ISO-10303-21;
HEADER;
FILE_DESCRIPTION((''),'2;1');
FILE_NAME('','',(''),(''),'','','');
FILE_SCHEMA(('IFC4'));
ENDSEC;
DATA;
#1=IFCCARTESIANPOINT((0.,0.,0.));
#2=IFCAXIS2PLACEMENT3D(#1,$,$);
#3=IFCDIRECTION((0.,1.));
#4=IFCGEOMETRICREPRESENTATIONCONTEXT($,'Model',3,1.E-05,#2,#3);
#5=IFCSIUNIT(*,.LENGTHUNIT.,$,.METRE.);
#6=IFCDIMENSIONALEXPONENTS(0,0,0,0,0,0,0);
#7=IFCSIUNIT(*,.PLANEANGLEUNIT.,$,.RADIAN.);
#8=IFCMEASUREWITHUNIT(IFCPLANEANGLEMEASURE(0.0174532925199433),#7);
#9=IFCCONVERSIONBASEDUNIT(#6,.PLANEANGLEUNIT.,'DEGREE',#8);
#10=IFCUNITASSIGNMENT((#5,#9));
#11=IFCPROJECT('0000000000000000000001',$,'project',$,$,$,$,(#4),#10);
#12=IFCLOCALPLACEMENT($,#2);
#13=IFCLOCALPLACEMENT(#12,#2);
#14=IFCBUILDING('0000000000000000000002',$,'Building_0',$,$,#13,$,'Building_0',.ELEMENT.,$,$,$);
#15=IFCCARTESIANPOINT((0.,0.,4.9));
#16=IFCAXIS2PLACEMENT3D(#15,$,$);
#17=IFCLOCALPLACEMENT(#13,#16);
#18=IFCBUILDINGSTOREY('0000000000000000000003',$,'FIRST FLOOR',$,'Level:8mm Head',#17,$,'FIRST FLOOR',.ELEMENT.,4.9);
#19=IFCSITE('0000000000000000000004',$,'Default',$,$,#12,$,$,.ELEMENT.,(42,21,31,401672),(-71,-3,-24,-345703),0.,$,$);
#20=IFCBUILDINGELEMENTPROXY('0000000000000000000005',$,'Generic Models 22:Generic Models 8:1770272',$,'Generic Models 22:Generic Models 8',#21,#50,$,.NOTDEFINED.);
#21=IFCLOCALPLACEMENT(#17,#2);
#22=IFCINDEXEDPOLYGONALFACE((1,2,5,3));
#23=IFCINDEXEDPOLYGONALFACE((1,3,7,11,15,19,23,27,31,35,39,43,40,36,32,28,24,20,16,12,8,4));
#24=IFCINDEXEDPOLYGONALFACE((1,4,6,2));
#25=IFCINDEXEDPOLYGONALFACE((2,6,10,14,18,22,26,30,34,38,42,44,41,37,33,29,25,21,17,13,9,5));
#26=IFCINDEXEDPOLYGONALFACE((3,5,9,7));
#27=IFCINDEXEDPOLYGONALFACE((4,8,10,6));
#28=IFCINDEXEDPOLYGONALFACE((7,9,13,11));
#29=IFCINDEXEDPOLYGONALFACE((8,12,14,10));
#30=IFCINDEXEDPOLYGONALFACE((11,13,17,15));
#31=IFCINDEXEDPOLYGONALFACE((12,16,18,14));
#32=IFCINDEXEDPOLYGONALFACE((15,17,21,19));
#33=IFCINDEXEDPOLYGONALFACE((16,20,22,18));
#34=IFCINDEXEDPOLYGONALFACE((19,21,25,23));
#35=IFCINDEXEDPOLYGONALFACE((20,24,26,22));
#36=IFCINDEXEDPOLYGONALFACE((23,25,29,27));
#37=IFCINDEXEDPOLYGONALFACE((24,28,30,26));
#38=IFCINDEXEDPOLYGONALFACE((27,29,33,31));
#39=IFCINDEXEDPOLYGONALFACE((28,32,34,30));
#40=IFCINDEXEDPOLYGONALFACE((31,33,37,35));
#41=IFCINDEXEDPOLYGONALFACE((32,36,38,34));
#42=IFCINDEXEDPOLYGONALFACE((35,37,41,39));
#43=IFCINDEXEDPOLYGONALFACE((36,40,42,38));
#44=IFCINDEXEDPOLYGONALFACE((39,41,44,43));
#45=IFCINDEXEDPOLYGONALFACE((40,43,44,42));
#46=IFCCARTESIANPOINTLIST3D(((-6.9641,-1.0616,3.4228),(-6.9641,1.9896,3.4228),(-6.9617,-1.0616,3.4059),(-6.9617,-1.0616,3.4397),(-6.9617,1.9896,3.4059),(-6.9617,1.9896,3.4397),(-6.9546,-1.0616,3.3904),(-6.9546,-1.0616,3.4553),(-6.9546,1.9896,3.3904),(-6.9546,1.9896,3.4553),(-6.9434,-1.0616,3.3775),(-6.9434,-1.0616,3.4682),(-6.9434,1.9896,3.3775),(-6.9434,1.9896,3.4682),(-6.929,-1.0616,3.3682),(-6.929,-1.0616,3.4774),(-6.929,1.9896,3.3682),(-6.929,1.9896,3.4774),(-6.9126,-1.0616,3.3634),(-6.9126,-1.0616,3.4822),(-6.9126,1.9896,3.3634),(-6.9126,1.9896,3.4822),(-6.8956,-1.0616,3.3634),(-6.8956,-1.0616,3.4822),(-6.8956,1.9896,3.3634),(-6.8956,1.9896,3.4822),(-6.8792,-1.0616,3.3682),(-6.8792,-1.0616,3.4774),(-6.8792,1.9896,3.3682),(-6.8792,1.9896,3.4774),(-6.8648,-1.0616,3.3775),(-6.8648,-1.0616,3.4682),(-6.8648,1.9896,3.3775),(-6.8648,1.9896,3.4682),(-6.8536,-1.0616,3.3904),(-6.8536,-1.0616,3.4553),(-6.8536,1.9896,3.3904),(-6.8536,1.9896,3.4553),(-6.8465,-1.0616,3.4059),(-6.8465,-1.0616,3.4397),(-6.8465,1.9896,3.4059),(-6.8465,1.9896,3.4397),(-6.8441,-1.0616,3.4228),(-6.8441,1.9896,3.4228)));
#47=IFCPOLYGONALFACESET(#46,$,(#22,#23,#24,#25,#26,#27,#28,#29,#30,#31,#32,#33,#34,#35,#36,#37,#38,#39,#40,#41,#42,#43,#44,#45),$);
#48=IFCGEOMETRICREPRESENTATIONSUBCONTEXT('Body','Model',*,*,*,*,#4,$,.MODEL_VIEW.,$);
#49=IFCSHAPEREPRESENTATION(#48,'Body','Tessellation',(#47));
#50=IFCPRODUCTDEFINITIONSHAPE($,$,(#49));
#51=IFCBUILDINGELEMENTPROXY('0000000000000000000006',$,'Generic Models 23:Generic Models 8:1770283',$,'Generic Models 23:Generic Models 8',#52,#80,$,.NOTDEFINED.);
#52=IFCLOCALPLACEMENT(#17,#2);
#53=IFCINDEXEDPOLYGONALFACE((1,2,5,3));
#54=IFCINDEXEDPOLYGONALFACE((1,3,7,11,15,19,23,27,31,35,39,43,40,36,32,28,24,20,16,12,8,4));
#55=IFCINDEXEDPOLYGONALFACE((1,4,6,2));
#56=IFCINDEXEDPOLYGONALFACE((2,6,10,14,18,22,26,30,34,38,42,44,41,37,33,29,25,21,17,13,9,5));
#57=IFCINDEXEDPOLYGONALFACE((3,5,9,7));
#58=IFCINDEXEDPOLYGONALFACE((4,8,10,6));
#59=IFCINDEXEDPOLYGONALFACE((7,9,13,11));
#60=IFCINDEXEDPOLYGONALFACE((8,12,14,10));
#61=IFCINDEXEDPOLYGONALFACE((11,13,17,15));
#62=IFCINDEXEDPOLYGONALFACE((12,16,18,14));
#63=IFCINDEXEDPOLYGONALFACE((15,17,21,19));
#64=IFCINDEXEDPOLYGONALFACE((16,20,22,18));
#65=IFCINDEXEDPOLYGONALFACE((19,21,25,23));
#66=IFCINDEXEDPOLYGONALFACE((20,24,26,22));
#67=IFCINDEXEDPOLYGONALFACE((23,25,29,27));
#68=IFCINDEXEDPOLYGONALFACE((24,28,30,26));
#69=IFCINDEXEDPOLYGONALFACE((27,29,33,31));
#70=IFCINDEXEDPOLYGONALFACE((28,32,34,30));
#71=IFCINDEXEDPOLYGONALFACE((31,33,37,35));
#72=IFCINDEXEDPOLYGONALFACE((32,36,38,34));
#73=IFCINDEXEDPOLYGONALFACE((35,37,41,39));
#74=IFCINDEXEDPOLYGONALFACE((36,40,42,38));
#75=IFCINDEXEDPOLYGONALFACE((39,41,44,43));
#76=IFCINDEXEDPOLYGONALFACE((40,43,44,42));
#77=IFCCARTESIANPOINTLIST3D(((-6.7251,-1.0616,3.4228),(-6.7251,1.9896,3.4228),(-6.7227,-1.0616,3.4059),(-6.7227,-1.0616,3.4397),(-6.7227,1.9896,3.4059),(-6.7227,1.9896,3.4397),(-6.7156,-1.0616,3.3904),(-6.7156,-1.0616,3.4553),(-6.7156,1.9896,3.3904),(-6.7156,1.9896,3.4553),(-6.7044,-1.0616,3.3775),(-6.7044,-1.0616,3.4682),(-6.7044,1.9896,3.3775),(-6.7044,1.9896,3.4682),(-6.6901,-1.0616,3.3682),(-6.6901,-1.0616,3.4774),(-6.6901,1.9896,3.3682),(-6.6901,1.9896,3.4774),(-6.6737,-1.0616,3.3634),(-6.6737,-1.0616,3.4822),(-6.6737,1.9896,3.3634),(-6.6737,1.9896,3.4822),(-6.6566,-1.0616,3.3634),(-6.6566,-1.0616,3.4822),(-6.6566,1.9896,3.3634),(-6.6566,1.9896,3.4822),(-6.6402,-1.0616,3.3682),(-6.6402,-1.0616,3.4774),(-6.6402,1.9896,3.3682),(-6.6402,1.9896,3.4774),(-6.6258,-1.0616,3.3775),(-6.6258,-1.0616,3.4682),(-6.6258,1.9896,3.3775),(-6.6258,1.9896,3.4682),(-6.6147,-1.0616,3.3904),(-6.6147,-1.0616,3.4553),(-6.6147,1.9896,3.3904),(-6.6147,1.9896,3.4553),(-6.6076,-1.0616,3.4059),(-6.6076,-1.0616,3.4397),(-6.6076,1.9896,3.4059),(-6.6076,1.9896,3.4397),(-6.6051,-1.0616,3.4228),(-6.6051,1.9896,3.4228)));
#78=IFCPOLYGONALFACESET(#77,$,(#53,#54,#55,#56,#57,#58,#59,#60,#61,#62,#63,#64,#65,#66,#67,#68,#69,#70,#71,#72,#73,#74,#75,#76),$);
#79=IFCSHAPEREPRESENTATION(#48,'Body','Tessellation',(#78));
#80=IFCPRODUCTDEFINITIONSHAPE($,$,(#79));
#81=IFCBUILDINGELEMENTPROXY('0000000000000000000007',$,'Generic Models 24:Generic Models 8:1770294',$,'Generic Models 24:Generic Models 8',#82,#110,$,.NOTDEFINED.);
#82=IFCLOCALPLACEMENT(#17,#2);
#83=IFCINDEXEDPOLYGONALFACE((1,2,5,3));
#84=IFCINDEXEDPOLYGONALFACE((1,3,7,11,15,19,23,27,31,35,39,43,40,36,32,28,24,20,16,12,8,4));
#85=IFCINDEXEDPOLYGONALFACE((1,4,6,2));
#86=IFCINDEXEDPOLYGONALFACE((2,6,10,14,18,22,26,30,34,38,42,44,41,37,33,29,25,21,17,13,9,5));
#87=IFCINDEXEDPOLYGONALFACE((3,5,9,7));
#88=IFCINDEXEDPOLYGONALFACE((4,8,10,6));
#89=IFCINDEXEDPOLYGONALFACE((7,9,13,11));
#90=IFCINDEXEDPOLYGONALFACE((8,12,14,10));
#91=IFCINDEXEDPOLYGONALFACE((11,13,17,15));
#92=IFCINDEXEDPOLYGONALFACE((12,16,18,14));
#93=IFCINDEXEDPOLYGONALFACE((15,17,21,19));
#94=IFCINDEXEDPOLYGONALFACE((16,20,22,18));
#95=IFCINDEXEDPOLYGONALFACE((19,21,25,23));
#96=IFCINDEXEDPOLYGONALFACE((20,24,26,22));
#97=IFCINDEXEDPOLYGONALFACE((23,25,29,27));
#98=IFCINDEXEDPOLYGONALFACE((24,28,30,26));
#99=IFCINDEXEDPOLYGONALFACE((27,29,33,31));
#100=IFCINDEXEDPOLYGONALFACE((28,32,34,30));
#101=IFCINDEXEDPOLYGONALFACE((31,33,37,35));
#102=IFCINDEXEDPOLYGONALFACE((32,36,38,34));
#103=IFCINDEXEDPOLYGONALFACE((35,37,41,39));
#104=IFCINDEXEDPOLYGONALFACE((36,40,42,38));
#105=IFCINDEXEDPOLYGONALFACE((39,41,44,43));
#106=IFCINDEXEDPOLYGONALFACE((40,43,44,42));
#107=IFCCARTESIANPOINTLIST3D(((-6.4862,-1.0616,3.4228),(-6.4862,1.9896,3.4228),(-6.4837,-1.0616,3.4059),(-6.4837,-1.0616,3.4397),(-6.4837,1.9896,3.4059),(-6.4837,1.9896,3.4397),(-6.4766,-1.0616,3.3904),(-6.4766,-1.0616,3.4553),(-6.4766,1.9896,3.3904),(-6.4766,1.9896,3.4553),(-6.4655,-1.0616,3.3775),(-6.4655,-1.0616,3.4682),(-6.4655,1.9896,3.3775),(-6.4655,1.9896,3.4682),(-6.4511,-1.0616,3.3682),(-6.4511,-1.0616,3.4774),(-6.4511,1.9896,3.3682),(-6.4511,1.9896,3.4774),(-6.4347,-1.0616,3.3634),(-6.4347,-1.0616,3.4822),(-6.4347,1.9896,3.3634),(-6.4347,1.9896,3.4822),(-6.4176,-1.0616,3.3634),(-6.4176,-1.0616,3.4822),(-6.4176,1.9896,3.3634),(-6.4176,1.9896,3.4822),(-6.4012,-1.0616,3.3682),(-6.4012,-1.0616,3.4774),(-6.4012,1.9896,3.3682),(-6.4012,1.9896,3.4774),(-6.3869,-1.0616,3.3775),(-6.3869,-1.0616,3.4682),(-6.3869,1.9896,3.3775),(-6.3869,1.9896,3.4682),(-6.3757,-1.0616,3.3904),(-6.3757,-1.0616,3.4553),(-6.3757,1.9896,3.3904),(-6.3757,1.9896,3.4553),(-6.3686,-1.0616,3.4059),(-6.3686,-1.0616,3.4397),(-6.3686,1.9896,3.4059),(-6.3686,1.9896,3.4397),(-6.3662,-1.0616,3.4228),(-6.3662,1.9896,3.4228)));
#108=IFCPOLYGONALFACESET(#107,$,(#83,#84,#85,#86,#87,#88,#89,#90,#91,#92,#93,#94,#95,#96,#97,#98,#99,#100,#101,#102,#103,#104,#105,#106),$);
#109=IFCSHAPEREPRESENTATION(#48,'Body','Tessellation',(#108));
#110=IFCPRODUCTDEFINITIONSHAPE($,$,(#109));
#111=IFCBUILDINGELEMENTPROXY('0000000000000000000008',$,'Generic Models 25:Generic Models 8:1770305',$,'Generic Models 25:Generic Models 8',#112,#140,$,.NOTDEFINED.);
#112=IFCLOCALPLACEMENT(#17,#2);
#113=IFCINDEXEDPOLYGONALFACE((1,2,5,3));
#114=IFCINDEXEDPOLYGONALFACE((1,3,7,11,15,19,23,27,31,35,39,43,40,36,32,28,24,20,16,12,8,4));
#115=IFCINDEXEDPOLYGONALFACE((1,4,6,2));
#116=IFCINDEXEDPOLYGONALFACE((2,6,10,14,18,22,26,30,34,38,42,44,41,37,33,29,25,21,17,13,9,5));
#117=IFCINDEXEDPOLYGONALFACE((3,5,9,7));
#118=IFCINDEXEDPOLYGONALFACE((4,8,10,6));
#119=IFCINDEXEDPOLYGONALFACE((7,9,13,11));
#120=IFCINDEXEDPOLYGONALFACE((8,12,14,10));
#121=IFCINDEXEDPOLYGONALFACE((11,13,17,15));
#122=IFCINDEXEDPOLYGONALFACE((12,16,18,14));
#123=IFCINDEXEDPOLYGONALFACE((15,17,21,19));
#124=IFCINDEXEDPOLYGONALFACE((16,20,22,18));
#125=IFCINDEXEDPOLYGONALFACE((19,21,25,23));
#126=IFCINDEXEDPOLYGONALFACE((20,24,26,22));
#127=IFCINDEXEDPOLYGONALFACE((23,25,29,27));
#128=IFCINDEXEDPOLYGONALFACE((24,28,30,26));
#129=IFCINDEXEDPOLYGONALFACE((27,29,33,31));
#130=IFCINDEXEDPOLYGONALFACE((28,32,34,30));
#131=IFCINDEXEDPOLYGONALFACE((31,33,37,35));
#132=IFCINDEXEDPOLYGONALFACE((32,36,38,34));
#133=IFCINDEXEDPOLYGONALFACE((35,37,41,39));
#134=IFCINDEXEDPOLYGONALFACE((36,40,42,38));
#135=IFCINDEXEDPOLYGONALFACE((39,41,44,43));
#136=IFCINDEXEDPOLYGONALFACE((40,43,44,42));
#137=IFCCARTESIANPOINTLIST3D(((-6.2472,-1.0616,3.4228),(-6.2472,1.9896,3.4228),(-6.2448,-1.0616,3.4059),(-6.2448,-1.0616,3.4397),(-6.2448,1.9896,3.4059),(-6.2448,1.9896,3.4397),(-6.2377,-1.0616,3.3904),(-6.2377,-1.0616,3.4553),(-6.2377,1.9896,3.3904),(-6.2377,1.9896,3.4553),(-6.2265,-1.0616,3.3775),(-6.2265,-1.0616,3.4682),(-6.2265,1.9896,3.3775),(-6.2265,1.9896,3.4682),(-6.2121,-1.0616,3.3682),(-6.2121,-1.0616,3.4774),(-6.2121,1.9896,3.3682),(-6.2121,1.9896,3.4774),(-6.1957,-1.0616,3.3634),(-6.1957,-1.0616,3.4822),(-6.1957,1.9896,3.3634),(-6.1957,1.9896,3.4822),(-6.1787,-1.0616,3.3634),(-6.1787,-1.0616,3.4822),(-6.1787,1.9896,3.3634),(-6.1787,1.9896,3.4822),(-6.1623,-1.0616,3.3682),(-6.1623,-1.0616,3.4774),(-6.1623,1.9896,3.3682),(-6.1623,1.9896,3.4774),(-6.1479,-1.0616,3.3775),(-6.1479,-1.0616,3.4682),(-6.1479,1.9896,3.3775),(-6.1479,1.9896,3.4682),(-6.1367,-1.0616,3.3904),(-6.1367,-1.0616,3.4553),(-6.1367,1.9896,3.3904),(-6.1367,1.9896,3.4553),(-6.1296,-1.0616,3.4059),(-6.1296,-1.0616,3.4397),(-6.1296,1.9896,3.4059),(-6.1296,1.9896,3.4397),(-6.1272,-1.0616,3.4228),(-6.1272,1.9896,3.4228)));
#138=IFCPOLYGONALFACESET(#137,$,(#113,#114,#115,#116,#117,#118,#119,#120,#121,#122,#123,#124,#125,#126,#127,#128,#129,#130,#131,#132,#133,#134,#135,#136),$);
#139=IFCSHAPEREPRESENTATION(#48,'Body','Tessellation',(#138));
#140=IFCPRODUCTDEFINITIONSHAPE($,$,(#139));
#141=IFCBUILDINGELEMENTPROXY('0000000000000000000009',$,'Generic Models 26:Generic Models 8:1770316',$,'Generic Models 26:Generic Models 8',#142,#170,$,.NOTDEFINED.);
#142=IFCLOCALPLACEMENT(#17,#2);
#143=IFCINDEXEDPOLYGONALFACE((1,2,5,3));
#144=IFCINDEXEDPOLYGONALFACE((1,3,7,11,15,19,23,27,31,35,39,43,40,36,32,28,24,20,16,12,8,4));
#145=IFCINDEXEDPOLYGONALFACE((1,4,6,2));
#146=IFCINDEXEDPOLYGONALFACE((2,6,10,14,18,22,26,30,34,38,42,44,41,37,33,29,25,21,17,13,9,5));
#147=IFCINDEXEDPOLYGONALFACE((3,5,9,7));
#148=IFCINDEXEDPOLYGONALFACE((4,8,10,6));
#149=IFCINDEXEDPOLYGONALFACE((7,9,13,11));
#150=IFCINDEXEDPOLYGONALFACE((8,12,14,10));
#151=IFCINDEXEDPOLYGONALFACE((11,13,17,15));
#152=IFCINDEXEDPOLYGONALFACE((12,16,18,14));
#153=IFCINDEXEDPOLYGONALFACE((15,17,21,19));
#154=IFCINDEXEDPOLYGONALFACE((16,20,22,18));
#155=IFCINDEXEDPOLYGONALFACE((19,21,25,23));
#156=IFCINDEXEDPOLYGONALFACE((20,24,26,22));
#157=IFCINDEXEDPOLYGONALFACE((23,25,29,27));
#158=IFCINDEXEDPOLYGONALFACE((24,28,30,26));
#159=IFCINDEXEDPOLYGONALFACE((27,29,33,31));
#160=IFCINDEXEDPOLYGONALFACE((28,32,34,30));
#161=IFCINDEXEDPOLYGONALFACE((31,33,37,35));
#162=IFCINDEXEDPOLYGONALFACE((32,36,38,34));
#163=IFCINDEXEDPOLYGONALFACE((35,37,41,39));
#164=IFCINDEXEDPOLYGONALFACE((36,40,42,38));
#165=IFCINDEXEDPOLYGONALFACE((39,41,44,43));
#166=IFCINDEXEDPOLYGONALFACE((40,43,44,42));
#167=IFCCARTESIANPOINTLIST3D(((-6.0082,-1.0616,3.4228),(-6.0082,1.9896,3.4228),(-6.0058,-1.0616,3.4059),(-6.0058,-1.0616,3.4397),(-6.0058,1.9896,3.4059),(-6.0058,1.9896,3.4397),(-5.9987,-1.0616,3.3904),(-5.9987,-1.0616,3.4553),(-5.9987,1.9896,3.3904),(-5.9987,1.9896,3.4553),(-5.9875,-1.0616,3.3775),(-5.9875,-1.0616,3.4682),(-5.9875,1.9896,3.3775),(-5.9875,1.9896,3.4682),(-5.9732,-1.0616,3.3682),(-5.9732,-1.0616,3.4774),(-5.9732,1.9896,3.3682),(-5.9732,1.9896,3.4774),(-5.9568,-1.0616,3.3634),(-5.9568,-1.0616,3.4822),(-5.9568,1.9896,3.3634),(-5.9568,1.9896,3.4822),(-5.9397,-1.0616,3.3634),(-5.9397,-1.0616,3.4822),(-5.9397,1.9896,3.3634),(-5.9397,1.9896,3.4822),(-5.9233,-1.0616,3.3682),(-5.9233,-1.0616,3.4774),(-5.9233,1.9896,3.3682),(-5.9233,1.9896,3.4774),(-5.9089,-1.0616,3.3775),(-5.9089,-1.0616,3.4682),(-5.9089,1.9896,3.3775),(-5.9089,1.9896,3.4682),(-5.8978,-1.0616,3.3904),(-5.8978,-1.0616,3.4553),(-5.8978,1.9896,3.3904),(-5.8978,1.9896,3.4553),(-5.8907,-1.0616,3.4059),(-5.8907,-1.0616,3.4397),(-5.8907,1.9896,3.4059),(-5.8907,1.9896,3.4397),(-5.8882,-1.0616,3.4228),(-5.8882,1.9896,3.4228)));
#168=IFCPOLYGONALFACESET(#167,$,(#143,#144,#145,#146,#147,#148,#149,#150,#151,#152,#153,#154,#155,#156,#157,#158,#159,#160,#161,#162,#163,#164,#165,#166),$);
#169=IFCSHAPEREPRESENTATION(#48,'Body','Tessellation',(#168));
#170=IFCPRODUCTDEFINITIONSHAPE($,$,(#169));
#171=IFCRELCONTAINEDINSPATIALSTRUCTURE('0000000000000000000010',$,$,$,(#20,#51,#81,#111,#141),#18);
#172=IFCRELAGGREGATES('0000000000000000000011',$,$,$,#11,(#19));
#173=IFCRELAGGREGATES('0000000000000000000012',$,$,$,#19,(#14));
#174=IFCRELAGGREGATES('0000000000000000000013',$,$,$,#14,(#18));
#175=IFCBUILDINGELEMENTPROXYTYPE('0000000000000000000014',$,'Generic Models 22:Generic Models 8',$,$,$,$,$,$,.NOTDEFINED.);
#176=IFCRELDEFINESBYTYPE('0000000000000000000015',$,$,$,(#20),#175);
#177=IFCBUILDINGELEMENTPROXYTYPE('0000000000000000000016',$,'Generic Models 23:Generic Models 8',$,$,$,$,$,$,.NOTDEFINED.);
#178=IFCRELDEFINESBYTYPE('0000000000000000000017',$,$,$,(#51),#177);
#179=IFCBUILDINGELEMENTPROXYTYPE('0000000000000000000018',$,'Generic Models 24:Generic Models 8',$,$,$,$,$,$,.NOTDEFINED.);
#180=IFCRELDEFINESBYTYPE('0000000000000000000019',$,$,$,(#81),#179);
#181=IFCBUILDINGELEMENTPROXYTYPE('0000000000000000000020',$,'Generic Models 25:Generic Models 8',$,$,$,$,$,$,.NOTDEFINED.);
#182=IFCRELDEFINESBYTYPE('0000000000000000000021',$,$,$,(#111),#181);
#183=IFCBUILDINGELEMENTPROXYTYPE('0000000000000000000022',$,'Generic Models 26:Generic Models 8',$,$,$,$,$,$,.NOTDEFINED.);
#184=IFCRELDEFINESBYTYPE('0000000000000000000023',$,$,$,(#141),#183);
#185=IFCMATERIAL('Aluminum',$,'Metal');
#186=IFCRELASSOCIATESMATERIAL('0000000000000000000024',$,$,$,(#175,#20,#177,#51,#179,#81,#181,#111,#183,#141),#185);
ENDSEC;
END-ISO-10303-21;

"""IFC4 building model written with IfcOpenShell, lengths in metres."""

from ifc_helpers import new_model, entity, si_unit, converted_unit, direction, frame, origin, place, context, subcontext, project, spatial, arc, indexed_curve, outline, extrude, source, transform, mapped, material, type_object, type_shapes, element, save


model = new_model("IFC4")

# Units and contexts
model_context = context("Model", 3, precision=1e-05, world=origin(), true_north=direction((0.0, 1.0)))
body_context = subcontext(model_context, "Body", "Model", "MODEL_VIEW")
ifc_project = project(units=[si_unit("LENGTHUNIT", "METRE"), converted_unit("PLANEANGLEUNIT", "DEGREE", entity("IfcPlaneAngleMeasure", 0.0174532925199433), si_unit("PLANEANGLEUNIT", "RADIAN"), dimensions=[0, 0, 0, 0, 0, 0, 0])], contexts=[model_context])

# Site, building, storey
site_placement = place(None, origin())
site = spatial("IfcSite", under=ifc_project, at=site_placement, Name="Default", CompositionType="ELEMENT", RefLatitude=(42, 21, 31, 401672), RefLongitude=(-71, -3, -24, -345703), RefElevation=0.0)
building_placement = place(site_placement, origin())
building = spatial("IfcBuilding", under=site, at=building_placement, Name="Building_0", LongName="Building_0", CompositionType="ELEMENT")
storey_placement = place(building_placement, frame((0.0, 0.0, 4.9)))
storey = spatial("IfcBuildingStorey", under=building, at=storey_placement, Name="FIRST FLOOR", ObjectType="Level:8mm Head", LongName="FIRST FLOOR", CompositionType="ELEMENT", Elevation=4.9)

# Building element proxies
ifc_material = material(Name="Aluminum", Category="Metal")
building_element_proxy_type_1 = type_object("IfcBuildingElementProxyType", Name="Generic Models 22:Generic Models 8", PredefinedType="NOTDEFINED", material=ifc_material)
shared_shape_1 = source(origin(), body_context, "Body", "SweptSolid", [
    extrude(outline(indexed_curve([(-0.06, 0.0), (0.0, -0.06), (0.06, 0.0), (0.0, 0.06)], segments=[arc(1, 2, 3), arc(3, 4, 1)], self_intersect=False)), frame((-6.9041, -1.0616, 8.3228), z_axis=(0.0, 1.0, 0.0), x_axis=(-1.0, 0.0, 0.0)), (0.0, 0.0, 1.0), 3.0512),
])
type_shapes(building_element_proxy_type_1, [shared_shape_1])
proxy_1_placement = place(storey_placement, frame((0.0, 0.0, -4.9)))
element("IfcBuildingElementProxy", 1, at=proxy_1_placement, inside=storey, type_object=building_element_proxy_type_1, material=ifc_material, Name="Generic Models 22:Generic Models 8:1770272", ObjectType="Generic Models 22:Generic Models 8", PredefinedType="NOTDEFINED", context=body_context, shape_type="MappedRepresentation", body=[
    mapped(shared_shape_1, transform((0.0, 0.0, 0.0), scale=1.0)),
])
building_element_proxy_type_2 = type_object("IfcBuildingElementProxyType", Name="Generic Models 23:Generic Models 8", PredefinedType="NOTDEFINED", material=ifc_material)
shared_shape_2 = source(origin(), body_context, "Body", "SweptSolid", [
    extrude(outline(indexed_curve([(-0.06, 0.0), (0.0, -0.06), (0.06, 0.0), (0.0, 0.06)], segments=[arc(1, 2, 3), arc(3, 4, 1)], self_intersect=False)), frame((-6.6651, -1.0616, 8.3228), z_axis=(0.0, 1.0, 0.0), x_axis=(-1.0, 0.0, 0.0)), (0.0, 0.0, 1.0), 3.0512),
])
type_shapes(building_element_proxy_type_2, [shared_shape_2])
proxy_2_placement = place(storey_placement, frame((0.0, 0.0, -4.9)))
element("IfcBuildingElementProxy", 2, at=proxy_2_placement, inside=storey, type_object=building_element_proxy_type_2, material=ifc_material, Name="Generic Models 23:Generic Models 8:1770283", ObjectType="Generic Models 23:Generic Models 8", PredefinedType="NOTDEFINED", context=body_context, shape_type="MappedRepresentation", body=[
    mapped(shared_shape_2, transform((0.0, 0.0, 0.0), scale=1.0)),
])
building_element_proxy_type_3 = type_object("IfcBuildingElementProxyType", Name="Generic Models 24:Generic Models 8", PredefinedType="NOTDEFINED", material=ifc_material)
shared_shape_3 = source(origin(), body_context, "Body", "SweptSolid", [
    extrude(outline(indexed_curve([(-0.06, 0.0), (0.0, -0.06), (0.06, 0.0), (0.0, 0.06)], segments=[arc(1, 2, 3), arc(3, 4, 1)], self_intersect=False)), frame((-6.4262, -1.0616, 8.3228), z_axis=(0.0, 1.0, 0.0), x_axis=(-1.0, 0.0, 0.0)), (0.0, 0.0, 1.0), 3.0512),
])
type_shapes(building_element_proxy_type_3, [shared_shape_3])
proxy_3_placement = place(storey_placement, frame((0.0, 0.0, -4.9)))
element("IfcBuildingElementProxy", 3, at=proxy_3_placement, inside=storey, type_object=building_element_proxy_type_3, material=ifc_material, Name="Generic Models 24:Generic Models 8:1770294", ObjectType="Generic Models 24:Generic Models 8", PredefinedType="NOTDEFINED", context=body_context, shape_type="MappedRepresentation", body=[
    mapped(shared_shape_3, transform((0.0, 0.0, 0.0), scale=1.0)),
])
building_element_proxy_type_4 = type_object("IfcBuildingElementProxyType", Name="Generic Models 25:Generic Models 8", PredefinedType="NOTDEFINED", material=ifc_material)
shared_shape_4 = source(origin(), body_context, "Body", "SweptSolid", [
    extrude(outline(indexed_curve([(-0.06, 0.0), (0.0, -0.06), (0.06, 0.0), (0.0, 0.06)], segments=[arc(1, 2, 3), arc(3, 4, 1)], self_intersect=False)), frame((-6.1872, -1.0616, 8.3228), z_axis=(0.0, 1.0, 0.0), x_axis=(-1.0, 0.0, 0.0)), (0.0, 0.0, 1.0), 3.0512),
])
type_shapes(building_element_proxy_type_4, [shared_shape_4])
proxy_4_placement = place(storey_placement, frame((0.0, 0.0, -4.9)))
element("IfcBuildingElementProxy", 4, at=proxy_4_placement, inside=storey, type_object=building_element_proxy_type_4, material=ifc_material, Name="Generic Models 25:Generic Models 8:1770305", ObjectType="Generic Models 25:Generic Models 8", PredefinedType="NOTDEFINED", context=body_context, shape_type="MappedRepresentation", body=[
    mapped(shared_shape_4, transform((0.0, 0.0, 0.0), scale=1.0)),
])
building_element_proxy_type_5 = type_object("IfcBuildingElementProxyType", Name="Generic Models 26:Generic Models 8", PredefinedType="NOTDEFINED", material=ifc_material)
shared_shape_5 = source(origin(), body_context, "Body", "SweptSolid", [
    extrude(outline(indexed_curve([(-0.06, 0.0), (0.0, -0.06), (0.06, 0.0), (0.0, 0.06)], segments=[arc(1, 2, 3), arc(3, 4, 1)], self_intersect=False)), frame((-5.9482, -1.0616, 8.3228), z_axis=(0.0, 1.0, 0.0), x_axis=(-1.0, 0.0, 0.0)), (0.0, 0.0, 1.0), 3.0512),
])
type_shapes(building_element_proxy_type_5, [shared_shape_5])
proxy_5_placement = place(storey_placement, frame((0.0, 0.0, -4.9)))
element("IfcBuildingElementProxy", 5, at=proxy_5_placement, inside=storey, type_object=building_element_proxy_type_5, material=ifc_material, Name="Generic Models 26:Generic Models 8:1770316", ObjectType="Generic Models 26:Generic Models 8", PredefinedType="NOTDEFINED", context=body_context, shape_type="MappedRepresentation", body=[
    mapped(shared_shape_5, transform((0.0, 0.0, 0.0), scale=1.0)),
])

save(model, "model.ifc")
